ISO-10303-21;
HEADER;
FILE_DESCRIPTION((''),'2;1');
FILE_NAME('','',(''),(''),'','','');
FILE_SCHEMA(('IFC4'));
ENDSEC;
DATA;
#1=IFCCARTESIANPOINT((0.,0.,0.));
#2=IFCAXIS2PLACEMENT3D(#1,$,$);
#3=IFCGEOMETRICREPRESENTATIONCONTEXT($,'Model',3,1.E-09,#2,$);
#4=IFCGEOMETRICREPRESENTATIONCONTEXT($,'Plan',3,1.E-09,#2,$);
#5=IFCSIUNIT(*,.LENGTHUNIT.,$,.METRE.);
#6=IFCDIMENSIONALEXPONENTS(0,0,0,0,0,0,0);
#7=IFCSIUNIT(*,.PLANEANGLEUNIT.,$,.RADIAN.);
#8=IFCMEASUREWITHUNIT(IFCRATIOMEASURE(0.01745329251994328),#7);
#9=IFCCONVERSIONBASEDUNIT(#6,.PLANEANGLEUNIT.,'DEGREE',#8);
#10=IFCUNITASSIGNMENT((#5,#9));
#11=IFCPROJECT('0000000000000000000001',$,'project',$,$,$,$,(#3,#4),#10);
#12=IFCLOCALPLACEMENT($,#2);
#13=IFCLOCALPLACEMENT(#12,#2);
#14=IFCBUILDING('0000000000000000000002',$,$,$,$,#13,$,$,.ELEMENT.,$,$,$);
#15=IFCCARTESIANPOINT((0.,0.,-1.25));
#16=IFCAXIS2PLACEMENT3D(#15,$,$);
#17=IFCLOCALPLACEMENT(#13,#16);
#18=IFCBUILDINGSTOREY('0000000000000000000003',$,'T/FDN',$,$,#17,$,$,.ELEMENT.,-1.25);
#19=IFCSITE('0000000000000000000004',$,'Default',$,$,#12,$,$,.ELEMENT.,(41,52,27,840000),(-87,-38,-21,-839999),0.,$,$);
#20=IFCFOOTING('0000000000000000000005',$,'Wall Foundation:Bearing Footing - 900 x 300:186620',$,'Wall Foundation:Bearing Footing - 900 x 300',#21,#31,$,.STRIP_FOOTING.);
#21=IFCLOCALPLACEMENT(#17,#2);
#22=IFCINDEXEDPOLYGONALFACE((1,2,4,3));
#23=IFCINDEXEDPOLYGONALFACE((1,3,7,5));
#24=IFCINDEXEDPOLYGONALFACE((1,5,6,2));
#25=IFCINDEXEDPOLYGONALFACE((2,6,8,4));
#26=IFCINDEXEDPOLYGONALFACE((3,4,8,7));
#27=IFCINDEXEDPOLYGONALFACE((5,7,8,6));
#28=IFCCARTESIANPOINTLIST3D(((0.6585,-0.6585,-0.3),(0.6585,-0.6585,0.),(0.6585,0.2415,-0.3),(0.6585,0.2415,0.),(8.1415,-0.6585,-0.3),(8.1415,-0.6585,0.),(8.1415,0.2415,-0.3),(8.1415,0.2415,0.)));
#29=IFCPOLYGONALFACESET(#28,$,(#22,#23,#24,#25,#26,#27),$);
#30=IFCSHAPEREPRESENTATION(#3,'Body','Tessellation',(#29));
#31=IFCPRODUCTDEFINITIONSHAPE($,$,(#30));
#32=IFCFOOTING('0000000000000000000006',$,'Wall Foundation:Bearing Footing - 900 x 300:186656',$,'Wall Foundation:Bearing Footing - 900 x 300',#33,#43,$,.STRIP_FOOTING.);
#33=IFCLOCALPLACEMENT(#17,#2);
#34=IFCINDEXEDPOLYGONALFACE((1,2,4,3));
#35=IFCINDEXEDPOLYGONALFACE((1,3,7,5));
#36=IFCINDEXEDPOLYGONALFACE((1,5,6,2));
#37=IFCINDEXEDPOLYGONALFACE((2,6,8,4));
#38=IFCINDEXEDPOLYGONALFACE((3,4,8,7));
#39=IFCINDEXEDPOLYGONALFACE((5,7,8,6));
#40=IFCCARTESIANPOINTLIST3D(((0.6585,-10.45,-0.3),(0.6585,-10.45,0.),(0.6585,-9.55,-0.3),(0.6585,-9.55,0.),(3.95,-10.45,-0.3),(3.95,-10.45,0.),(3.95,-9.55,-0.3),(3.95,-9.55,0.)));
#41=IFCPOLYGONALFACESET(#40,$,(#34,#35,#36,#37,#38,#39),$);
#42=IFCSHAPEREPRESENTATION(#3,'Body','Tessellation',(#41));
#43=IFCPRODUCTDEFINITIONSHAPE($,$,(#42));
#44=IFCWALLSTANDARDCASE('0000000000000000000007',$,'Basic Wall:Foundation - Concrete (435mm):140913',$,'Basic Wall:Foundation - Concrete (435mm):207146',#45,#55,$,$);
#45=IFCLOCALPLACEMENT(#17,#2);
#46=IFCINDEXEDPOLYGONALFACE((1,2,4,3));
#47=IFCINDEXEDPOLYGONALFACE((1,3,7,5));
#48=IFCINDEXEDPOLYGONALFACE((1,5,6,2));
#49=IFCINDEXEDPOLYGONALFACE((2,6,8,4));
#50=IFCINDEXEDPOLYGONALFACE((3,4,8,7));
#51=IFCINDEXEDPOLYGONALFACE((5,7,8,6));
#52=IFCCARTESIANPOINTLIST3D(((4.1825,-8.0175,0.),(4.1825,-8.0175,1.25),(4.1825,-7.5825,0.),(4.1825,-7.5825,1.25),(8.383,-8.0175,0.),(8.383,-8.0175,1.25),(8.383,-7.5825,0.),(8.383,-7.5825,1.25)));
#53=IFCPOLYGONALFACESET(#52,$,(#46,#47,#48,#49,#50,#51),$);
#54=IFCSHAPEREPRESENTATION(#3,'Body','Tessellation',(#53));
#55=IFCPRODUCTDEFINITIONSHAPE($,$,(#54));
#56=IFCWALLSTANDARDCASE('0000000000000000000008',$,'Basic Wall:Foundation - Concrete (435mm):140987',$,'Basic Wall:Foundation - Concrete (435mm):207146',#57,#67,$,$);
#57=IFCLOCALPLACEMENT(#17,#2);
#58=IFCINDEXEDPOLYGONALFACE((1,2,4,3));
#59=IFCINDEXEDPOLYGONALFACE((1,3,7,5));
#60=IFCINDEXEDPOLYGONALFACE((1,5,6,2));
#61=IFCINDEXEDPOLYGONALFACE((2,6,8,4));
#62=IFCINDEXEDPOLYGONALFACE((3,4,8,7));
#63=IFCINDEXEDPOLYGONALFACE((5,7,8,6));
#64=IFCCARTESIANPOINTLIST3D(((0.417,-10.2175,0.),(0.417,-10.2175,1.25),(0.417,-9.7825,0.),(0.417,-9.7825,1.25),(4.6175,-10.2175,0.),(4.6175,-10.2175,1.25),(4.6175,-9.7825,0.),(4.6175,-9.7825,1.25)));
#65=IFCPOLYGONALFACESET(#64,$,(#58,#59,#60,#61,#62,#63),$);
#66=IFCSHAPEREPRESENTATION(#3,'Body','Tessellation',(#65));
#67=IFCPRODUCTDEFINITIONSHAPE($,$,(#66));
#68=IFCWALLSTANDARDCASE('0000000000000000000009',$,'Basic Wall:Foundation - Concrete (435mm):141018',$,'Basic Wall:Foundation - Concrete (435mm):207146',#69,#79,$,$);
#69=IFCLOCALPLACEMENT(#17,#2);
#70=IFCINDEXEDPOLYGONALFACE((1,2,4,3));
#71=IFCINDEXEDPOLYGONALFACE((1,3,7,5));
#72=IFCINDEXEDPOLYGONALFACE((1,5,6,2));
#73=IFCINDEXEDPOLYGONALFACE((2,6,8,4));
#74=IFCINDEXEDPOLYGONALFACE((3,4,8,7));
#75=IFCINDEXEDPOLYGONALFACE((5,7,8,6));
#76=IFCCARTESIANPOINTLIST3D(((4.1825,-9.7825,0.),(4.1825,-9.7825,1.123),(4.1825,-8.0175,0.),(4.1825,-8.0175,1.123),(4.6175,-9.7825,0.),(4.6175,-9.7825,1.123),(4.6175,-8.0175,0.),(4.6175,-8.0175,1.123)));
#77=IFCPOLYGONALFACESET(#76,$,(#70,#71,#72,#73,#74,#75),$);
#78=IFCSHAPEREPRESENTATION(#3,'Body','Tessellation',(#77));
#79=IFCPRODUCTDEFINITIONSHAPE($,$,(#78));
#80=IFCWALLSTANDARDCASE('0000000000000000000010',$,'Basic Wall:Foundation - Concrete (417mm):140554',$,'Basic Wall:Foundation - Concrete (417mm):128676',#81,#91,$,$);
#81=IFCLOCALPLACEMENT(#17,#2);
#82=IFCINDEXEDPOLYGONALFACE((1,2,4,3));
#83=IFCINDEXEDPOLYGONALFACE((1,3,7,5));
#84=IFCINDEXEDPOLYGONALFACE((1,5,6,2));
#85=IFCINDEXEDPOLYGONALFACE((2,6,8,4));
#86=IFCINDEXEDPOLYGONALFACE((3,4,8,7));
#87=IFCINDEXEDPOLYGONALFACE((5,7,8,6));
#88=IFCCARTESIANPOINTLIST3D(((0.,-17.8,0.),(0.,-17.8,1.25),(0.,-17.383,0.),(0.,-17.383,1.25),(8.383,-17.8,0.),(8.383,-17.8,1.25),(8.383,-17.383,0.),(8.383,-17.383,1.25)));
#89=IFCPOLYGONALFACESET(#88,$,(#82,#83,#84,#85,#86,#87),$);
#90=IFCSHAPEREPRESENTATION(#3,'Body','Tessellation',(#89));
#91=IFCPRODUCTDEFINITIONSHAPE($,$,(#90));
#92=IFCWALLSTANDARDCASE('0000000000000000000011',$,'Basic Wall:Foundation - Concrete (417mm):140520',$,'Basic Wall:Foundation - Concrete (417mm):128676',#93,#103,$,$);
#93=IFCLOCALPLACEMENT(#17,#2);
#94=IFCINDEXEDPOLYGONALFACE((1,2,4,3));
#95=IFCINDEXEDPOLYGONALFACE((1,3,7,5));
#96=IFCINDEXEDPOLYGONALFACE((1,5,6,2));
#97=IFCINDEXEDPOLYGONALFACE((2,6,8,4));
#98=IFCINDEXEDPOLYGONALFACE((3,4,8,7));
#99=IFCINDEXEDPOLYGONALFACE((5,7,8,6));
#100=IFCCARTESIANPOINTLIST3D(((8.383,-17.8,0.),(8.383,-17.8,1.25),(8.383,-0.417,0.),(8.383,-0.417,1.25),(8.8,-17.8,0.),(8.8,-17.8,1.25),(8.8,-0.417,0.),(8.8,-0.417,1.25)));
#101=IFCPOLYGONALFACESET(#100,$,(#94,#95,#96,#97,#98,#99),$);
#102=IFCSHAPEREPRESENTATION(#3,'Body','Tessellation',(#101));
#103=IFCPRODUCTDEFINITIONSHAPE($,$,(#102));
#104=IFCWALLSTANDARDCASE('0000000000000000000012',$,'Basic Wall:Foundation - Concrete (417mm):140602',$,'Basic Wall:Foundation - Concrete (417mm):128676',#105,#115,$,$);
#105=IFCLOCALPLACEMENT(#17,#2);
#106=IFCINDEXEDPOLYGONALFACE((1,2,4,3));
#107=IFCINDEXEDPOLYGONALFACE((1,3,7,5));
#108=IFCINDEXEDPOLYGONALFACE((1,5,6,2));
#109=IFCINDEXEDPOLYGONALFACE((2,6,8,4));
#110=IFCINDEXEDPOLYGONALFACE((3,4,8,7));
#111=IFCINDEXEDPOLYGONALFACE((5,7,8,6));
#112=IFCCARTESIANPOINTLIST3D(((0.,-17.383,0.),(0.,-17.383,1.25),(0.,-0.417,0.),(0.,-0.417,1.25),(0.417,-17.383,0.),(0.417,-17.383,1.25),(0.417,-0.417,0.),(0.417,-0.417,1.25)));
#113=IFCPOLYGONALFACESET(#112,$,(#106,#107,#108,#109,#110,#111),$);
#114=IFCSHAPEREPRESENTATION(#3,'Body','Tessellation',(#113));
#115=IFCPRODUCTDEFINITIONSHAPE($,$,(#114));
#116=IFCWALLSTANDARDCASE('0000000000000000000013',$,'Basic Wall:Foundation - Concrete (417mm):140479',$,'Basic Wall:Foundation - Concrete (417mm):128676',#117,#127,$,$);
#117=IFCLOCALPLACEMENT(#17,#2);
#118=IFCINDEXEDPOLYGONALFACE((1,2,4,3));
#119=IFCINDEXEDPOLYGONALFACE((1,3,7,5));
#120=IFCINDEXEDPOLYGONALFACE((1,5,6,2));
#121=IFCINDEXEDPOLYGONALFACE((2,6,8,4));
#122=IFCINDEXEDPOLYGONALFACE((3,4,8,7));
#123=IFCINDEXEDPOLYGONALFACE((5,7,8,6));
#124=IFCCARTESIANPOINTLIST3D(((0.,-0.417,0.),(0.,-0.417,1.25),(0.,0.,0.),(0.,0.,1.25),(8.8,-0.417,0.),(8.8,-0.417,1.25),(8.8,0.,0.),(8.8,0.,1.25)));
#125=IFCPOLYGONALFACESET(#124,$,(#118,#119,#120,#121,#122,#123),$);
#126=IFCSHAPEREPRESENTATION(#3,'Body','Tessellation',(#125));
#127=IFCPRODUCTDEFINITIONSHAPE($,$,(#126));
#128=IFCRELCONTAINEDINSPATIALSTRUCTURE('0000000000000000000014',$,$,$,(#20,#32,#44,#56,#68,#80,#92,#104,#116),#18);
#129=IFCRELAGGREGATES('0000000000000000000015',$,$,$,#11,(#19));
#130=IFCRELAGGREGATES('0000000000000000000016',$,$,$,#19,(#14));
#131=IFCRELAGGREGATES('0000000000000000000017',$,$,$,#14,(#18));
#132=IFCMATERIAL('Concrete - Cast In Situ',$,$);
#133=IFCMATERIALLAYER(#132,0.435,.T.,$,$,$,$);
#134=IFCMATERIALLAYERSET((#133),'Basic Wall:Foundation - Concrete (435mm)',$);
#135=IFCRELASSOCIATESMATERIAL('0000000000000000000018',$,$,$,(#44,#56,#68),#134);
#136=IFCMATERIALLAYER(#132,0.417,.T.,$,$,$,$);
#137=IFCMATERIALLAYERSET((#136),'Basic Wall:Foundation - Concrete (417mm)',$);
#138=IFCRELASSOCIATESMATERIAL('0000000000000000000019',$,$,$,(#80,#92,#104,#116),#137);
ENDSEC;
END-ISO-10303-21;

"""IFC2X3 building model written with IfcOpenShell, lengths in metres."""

from ifc_helpers import new_model, entity, si_unit, converted_unit, frame, frame_2d, origin, origin_2d_with_axis, place, context, project, spatial, rectangle, extrude, material, layer, layer_set, layer_usage, element, save


model = new_model("IFC2X3")

# Units and contexts
model_context = context("Model", 3, precision=1e-09, world=origin())
plan_context = context("Plan", 3, precision=1e-09, world=origin())
ifc_project = project(units=[si_unit("LENGTHUNIT", "METRE"), converted_unit("PLANEANGLEUNIT", "DEGREE", entity("IfcRatioMeasure", 0.01745329251994328), si_unit("PLANEANGLEUNIT", "RADIAN"), dimensions=[0, 0, 0, 0, 0, 0, 0])], contexts=[model_context, plan_context])

# Site, building, storey
site_placement = place(None, origin())
site = spatial("IfcSite", under=ifc_project, at=site_placement, Name="Default", CompositionType="ELEMENT", RefLatitude=(41, 52, 27, 840000), RefLongitude=(-87, -38, -21, -839999), RefElevation=0.0)
building_placement = place(site_placement, origin())
building = spatial("IfcBuilding", under=site, at=building_placement, CompositionType="ELEMENT")
storey_placement = place(building_placement, frame((0.0, 0.0, -1.25)))
storey = spatial("IfcBuildingStorey", under=building, at=storey_placement, Name="T/FDN", CompositionType="ELEMENT", Elevation=-1.25)

# Footings
footing_1_placement = place(storey_placement, origin())
element("IfcFooting", 1, at=footing_1_placement, inside=storey, Name="Wall Foundation:Bearing Footing - 900 x 300:186620", ObjectType="Wall Foundation:Bearing Footing - 900 x 300", PredefinedType="STRIP_FOOTING", context=model_context, shape_type="SweptSolid", body=[
    extrude(rectangle(XDim=7.483, YDim=0.9, at=origin_2d_with_axis()), frame((4.4, -0.2085, -0.3), z_axis=(0.0, 0.0, 1.0), x_axis=(-1.0, 0.0, 0.0)), (0.0, 0.0, 1.0), 0.3),
])
footing_2_placement = place(storey_placement, origin())
element("IfcFooting", 2, at=footing_2_placement, inside=storey, Name="Wall Foundation:Bearing Footing - 900 x 300:186656", ObjectType="Wall Foundation:Bearing Footing - 900 x 300", PredefinedType="STRIP_FOOTING", context=model_context, shape_type="SweptSolid", body=[
    extrude(rectangle(XDim=3.2915, YDim=0.9, at=origin_2d_with_axis()), frame((2.3042, -10.0, -0.3)), (0.0, 0.0, 1.0), 0.3),
])

# Walls
ifc_material = material(Name="Concrete - Cast In Situ")
ifc_layer_1 = layer(ifc_material, 0.435, ventilated=True)
ifc_layer_set_1 = layer_set([ifc_layer_1], Name="Basic Wall:Foundation - Concrete (435mm)")
ifc_layer_usage_1 = layer_usage(ifc_layer_set_1, "AXIS2", "NEGATIVE", 0.2175)
wall_1_placement = place(storey_placement, frame((8.383, -7.8, 0.0), z_axis=(0.0, 0.0, 1.0), x_axis=(-1.0, 0.0, 0.0)))
element("IfcWallStandardCase", 3, at=wall_1_placement, inside=storey, material=ifc_layer_usage_1, Name="Basic Wall:Foundation - Concrete (435mm):140913", ObjectType="Basic Wall:Foundation - Concrete (435mm):207146", context=model_context, shape_type="SweptSolid", body=[
    extrude(rectangle(XDim=4.2005, YDim=0.435, at=frame_2d((2.1002, 0.0), x_axis=(-1.0, 0.0))), origin(), (0.0, 0.0, 1.0), 1.25),
])
wall_2_placement = place(storey_placement, frame((0.417, -10.0, 0.0)))
element("IfcWallStandardCase", 4, at=wall_2_placement, inside=storey, material=ifc_layer_usage_1, Name="Basic Wall:Foundation - Concrete (435mm):140987", ObjectType="Basic Wall:Foundation - Concrete (435mm):207146", context=model_context, shape_type="SweptSolid", body=[
    extrude(rectangle(XDim=4.2005, YDim=0.435, at=frame_2d((2.1002, 0.0), x_axis=(-1.0, 0.0))), origin(), (0.0, 0.0, 1.0), 1.25),
])
wall_3_placement = place(storey_placement, frame((4.4, -9.7825, 0.0), z_axis=(0.0, 0.0, 1.0), x_axis=(0.0, 1.0, 0.0)))
element("IfcWallStandardCase", 5, at=wall_3_placement, inside=storey, material=ifc_layer_usage_1, Name="Basic Wall:Foundation - Concrete (435mm):141018", ObjectType="Basic Wall:Foundation - Concrete (435mm):207146", context=model_context, shape_type="SweptSolid", body=[
    extrude(rectangle(XDim=1.765, YDim=0.435, at=frame_2d((0.8825, 0.0), x_axis=(-1.0, 0.0))), origin(), (0.0, 0.0, 1.0), 1.123),
])
ifc_layer_2 = layer(ifc_material, 0.417, ventilated=True)
ifc_layer_set_2 = layer_set([ifc_layer_2], Name="Basic Wall:Foundation - Concrete (417mm)")
ifc_layer_usage_2 = layer_usage(ifc_layer_set_2, "AXIS2", "NEGATIVE", 0.2085)
wall_4_placement = place(storey_placement, frame((8.383, -17.5915, 0.0), z_axis=(0.0, 0.0, 1.0), x_axis=(-1.0, 0.0, 0.0)))
element("IfcWallStandardCase", 6, at=wall_4_placement, inside=storey, material=ifc_layer_usage_2, Name="Basic Wall:Foundation - Concrete (417mm):140554", ObjectType="Basic Wall:Foundation - Concrete (417mm):128676", context=model_context, shape_type="SweptSolid", body=[
    extrude(rectangle(XDim=8.383, YDim=0.417, at=frame_2d((4.1915, 0.0), x_axis=(-1.0, 0.0))), origin(), (0.0, 0.0, 1.0), 1.25),
])
wall_5_placement = place(storey_placement, frame((8.5915, -0.417, 0.0), z_axis=(0.0, 0.0, 1.0), x_axis=(0.0, -1.0, 0.0)))
element("IfcWallStandardCase", 7, at=wall_5_placement, inside=storey, material=ifc_layer_usage_2, Name="Basic Wall:Foundation - Concrete (417mm):140520", ObjectType="Basic Wall:Foundation - Concrete (417mm):128676", context=model_context, shape_type="SweptSolid", body=[
    extrude(rectangle(XDim=17.383, YDim=0.417, at=frame_2d((8.6915, 0.0), x_axis=(-1.0, 0.0))), origin(), (0.0, 0.0, 1.0), 1.25),
])
wall_6_placement = place(storey_placement, frame((0.2085, -17.383, 0.0), z_axis=(0.0, 0.0, 1.0), x_axis=(0.0, 1.0, 0.0)))
element("IfcWallStandardCase", 8, at=wall_6_placement, inside=storey, material=ifc_layer_usage_2, Name="Basic Wall:Foundation - Concrete (417mm):140602", ObjectType="Basic Wall:Foundation - Concrete (417mm):128676", context=model_context, shape_type="SweptSolid", body=[
    extrude(rectangle(XDim=16.966, YDim=0.417, at=frame_2d((8.483, 0.0), x_axis=(-1.0, 0.0))), origin(), (0.0, 0.0, 1.0), 1.25),
])
wall_7_placement = place(storey_placement, frame((0.0, -0.2085, 0.0)))
element("IfcWallStandardCase", 9, at=wall_7_placement, inside=storey, material=ifc_layer_usage_2, Name="Basic Wall:Foundation - Concrete (417mm):140479", ObjectType="Basic Wall:Foundation - Concrete (417mm):128676", context=model_context, shape_type="SweptSolid", body=[
    extrude(rectangle(XDim=8.8, YDim=0.417, at=frame_2d((4.4, 0.0), x_axis=(-1.0, 0.0))), origin(), (0.0, 0.0, 1.0), 1.25),
])

save(model, "model.ifc")
